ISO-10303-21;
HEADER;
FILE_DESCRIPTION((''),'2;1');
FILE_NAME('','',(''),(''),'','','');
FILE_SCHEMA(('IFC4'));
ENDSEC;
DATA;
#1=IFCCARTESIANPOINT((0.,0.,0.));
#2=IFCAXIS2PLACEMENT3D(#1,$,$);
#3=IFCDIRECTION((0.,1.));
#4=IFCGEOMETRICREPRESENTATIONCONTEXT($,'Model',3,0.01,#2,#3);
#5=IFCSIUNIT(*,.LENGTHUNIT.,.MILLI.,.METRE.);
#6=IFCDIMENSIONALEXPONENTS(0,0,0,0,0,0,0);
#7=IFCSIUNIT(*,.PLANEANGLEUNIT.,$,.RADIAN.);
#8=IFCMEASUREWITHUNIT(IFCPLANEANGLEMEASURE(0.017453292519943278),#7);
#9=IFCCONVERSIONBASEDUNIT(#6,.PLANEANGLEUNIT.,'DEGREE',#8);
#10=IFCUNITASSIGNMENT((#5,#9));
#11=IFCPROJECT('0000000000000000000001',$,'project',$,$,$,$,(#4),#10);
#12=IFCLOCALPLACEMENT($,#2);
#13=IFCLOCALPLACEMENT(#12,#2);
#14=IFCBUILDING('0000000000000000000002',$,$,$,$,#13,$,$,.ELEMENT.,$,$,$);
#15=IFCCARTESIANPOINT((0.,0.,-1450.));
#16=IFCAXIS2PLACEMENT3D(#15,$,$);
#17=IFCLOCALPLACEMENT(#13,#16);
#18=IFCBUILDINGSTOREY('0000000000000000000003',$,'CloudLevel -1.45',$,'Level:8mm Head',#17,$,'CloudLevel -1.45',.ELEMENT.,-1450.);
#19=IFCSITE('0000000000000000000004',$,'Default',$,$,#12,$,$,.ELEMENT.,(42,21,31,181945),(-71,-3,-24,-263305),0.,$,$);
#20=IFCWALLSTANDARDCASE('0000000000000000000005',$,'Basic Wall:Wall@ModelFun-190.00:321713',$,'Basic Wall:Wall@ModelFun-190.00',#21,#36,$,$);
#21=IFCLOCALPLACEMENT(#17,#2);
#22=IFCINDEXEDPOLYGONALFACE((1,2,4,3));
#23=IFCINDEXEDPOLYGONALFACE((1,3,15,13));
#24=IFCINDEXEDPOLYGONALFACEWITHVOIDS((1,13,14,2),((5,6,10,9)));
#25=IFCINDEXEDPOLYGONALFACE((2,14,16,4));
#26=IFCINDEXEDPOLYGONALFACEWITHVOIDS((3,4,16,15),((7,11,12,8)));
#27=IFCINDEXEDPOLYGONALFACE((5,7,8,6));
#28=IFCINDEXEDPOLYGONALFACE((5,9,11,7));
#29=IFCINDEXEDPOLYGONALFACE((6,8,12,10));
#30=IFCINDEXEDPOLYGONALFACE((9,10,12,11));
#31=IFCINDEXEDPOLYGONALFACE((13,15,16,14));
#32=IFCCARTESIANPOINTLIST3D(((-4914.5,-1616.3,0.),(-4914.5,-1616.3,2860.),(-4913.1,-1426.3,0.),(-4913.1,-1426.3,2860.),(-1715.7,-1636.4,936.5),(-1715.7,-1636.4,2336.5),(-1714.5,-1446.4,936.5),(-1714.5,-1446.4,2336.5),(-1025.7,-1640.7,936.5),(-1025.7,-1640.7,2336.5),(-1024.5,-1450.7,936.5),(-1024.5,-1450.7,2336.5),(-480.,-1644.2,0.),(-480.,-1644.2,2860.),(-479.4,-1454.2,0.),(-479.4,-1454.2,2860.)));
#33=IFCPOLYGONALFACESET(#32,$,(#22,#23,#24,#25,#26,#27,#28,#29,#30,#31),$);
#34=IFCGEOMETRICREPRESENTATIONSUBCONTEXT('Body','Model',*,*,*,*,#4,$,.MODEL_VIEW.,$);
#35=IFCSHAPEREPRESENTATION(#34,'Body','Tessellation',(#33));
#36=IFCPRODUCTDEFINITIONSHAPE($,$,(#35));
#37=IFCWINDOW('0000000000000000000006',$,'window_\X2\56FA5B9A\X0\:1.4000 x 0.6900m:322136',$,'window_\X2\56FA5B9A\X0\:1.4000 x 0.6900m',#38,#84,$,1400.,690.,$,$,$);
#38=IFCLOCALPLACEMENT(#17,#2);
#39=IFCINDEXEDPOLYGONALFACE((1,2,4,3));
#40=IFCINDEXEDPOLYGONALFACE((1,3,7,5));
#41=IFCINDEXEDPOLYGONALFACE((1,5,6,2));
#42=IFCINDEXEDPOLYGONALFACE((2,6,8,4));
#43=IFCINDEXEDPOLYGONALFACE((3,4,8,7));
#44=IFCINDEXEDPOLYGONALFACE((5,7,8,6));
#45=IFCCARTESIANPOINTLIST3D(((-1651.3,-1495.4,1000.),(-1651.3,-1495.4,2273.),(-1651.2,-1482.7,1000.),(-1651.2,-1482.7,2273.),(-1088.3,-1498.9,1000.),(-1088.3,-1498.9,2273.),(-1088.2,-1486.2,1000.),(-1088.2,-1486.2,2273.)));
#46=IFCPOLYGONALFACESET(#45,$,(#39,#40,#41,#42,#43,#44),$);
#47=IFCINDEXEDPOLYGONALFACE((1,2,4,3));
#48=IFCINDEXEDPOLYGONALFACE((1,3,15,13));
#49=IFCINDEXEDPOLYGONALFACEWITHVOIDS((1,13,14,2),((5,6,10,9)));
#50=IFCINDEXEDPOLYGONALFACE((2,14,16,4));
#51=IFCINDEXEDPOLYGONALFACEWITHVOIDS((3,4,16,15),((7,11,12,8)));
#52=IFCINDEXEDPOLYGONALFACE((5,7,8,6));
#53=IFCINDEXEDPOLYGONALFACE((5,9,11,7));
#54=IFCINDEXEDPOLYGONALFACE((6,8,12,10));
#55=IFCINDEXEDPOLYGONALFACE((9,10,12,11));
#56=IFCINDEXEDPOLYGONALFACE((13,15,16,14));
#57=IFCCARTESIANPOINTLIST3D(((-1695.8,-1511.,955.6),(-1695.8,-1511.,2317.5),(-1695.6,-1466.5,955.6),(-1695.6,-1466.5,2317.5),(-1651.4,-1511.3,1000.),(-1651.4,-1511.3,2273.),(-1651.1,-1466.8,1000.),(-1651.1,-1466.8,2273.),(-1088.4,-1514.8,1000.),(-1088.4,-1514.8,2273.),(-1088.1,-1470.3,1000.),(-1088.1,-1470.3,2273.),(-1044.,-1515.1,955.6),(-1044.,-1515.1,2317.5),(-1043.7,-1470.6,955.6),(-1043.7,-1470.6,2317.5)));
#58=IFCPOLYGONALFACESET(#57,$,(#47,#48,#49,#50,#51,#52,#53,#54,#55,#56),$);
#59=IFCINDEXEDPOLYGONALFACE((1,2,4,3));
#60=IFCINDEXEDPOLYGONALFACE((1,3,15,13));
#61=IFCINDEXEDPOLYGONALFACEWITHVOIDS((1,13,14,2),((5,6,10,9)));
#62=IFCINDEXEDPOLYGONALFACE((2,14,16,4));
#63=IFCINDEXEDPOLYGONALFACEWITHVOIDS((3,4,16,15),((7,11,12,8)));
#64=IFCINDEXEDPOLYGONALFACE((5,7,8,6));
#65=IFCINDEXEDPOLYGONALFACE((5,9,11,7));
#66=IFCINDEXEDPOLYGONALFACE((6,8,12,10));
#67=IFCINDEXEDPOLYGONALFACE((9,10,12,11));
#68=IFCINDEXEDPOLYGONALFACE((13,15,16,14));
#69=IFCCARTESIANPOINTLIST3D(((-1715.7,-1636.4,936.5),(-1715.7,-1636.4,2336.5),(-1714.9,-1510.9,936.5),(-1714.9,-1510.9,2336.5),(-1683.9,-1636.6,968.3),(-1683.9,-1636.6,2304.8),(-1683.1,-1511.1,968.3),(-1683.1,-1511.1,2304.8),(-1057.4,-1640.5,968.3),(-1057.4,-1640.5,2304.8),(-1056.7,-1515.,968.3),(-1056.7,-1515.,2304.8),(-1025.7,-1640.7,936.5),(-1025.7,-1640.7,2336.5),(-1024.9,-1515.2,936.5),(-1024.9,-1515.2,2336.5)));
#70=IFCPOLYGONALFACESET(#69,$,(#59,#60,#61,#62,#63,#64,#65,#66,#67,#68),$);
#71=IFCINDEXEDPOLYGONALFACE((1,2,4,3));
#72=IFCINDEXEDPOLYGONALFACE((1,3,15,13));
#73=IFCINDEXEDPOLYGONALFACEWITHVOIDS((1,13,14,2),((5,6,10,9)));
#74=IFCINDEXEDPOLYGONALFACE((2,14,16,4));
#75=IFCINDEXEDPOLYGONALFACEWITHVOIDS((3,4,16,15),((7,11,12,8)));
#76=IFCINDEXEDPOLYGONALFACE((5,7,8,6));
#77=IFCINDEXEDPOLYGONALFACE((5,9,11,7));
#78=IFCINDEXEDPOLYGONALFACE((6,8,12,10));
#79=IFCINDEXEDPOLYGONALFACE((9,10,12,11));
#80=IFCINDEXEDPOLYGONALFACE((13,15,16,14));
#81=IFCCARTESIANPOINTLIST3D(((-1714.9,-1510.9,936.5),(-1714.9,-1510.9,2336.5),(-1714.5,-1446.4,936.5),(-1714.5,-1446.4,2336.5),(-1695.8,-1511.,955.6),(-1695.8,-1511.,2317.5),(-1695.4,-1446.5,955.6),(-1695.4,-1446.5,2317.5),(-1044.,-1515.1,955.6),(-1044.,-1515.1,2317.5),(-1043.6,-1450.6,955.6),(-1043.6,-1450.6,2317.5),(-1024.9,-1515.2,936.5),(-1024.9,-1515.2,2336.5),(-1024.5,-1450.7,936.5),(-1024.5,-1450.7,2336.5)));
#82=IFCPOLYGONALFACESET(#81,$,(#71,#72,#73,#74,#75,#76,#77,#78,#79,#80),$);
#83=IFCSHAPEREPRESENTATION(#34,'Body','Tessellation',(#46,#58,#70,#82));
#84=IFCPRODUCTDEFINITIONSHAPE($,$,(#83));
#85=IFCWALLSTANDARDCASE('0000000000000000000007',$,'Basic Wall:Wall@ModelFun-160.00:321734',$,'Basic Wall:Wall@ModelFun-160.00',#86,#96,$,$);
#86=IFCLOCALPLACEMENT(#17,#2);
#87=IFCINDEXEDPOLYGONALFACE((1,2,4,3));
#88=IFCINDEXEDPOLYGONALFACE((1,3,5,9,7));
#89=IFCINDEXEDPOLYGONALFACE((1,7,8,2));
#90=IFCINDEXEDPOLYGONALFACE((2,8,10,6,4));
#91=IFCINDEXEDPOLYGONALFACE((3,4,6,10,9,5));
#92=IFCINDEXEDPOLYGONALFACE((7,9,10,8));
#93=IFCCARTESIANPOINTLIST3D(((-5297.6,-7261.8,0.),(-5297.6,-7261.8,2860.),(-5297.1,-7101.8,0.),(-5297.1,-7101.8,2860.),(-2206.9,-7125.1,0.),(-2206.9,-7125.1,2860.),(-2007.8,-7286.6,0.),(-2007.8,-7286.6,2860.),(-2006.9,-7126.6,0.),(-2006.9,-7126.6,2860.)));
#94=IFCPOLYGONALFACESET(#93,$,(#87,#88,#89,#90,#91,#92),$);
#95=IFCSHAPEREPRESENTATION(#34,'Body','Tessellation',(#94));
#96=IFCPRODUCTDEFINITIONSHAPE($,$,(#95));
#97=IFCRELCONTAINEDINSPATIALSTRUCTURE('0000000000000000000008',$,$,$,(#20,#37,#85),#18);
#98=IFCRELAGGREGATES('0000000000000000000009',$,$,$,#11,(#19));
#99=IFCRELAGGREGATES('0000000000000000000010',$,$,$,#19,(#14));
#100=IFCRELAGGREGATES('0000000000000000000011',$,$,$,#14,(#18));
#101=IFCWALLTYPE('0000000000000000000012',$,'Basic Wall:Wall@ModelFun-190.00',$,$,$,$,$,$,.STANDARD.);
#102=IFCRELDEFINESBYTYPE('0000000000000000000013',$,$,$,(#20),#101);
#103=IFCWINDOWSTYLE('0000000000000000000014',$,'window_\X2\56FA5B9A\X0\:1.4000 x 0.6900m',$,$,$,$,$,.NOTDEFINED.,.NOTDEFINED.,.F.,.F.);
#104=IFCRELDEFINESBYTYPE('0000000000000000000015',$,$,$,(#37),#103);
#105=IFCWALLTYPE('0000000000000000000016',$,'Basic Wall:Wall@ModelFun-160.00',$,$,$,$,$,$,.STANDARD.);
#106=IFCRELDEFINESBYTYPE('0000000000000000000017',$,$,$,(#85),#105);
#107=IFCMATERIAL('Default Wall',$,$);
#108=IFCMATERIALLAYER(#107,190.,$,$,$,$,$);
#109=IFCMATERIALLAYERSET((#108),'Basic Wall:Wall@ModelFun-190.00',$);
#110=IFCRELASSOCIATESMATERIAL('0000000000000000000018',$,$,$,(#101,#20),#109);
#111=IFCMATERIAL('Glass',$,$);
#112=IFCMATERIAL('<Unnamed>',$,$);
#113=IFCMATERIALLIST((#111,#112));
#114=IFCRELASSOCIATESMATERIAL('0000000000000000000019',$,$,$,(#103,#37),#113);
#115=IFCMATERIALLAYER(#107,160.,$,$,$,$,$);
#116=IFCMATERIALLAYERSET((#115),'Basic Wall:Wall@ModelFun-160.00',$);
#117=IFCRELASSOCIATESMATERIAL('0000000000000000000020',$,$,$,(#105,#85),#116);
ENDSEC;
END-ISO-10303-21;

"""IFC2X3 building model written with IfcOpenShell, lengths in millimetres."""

from ifc_helpers import new_model, entity, si_unit, converted_unit, direction, frame, frame_2d, origin, place, context, subcontext, project, spatial, polyline, rectangle, outline, extrude, source, transform, mapped, material, material_list, layer, layer_set, layer_usage, type_object, type_shapes, element, fill, save


model = new_model("IFC2X3")

# Units and contexts
model_context = context("Model", 3, precision=0.01, world=origin(), true_north=direction((0.0, 1.0)))
body_context = subcontext(model_context, "Body", "Model", "MODEL_VIEW")
ifc_project = project(units=[si_unit("LENGTHUNIT", "METRE", prefix="MILLI"), converted_unit("PLANEANGLEUNIT", "DEGREE", entity("IfcPlaneAngleMeasure", 0.017453292519943278), si_unit("PLANEANGLEUNIT", "RADIAN"), dimensions=[0, 0, 0, 0, 0, 0, 0])], contexts=[model_context])

# Site, building, storey
site_placement = place(None, origin())
site = spatial("IfcSite", under=ifc_project, at=site_placement, Name="Default", CompositionType="ELEMENT", RefLatitude=(42, 21, 31, 181945), RefLongitude=(-71, -3, -24, -263305), RefElevation=0.0)
building_placement = place(site_placement, origin())
building = spatial("IfcBuilding", under=site, at=building_placement, CompositionType="ELEMENT")
storey_placement = place(building_placement, frame((0.0, 0.0, -1450.0)))
storey = spatial("IfcBuildingStorey", under=building, at=storey_placement, Name="CloudLevel -1.45", ObjectType="Level:8mm Head", LongName="CloudLevel -1.45", CompositionType="ELEMENT", Elevation=-1450.0)

# Shared definitions
ifc_material_1 = material(Name="Default Wall")
ifc_material_2 = material(Name="Glass")
ifc_material_3 = material(Name="<Unnamed>")
ifc_material_list = material_list([ifc_material_2, ifc_material_3])

# Wall, opening, window
ifc_layer_1 = layer(ifc_material_1, 190.0)
ifc_layer_set_1 = layer_set([ifc_layer_1], Name="Basic Wall:Wall@ModelFun-190.00")
ifc_layer_usage_1 = layer_usage(ifc_layer_set_1, "AXIS2", "NEGATIVE", 95.0)
wall_type_1 = type_object("IfcWallType", Name="Basic Wall:Wall@ModelFun-190.00", PredefinedType="STANDARD", material=ifc_layer_set_1)
wall_1_placement = place(storey_placement, frame((-479.4, -1549.2, 0.0), z_axis=(0.0, 0.0, 1.0), x_axis=(-0.99998, 0.006278, 0.0)))
wall_1 = element("IfcWallStandardCase", 1, at=wall_1_placement, inside=storey, type_object=wall_type_1, material=ifc_layer_usage_1, Name="Basic Wall:Wall@ModelFun-190.00:321713", ObjectType="Basic Wall:Wall@ModelFun-190.00", context=body_context, shape_type="SweptSolid", body=[
    extrude(outline(polyline([(4434.4, -95.0), (4434.6, 95.0), (4194.6, 95.0), (1694.8, 95.0), (1494.8, 95.0), (0.0, 95.0), (0.6, -95.0), (142.8, -95.0), (342.8, -95.0), (1346.6, -95.0), (1586.6, -95.0), (4434.4, -95.0)])), origin(), (0.0, 0.0, 1.0), 2860.0),
])
opening_1_placement = place(wall_1_placement, frame((1235.7, 95.0, 936.5)))
opening_1 = element("IfcOpeningElement", 2, at=opening_1_placement, cuts=wall_1, ObjectType="Opening", context=body_context, shape_type="SweptSolid", body=[
    extrude(rectangle(XDim=1400.0, YDim=690.0, at=frame_2d((700.0, 345.0), x_axis=(-1.0, 0.0))), frame((0.0, 0.0, 0.0), z_axis=(0.0, -1.0, 0.0), x_axis=(0.0, 0.0, 1.0)), (0.0, 0.0, 1.0), 190.0),
])
window_style_1 = type_object("IfcWindowStyle", Name="window_固定:1.4000 x 0.6900m", ConstructionType="NOTDEFINED", OperationType="NOTDEFINED", ParameterTakesPrecedence=False, Sizeable=False, material=ifc_material_list)
shared_shape_1 = source(origin(), body_context, "Body", "SweptSolid", [
    extrude(rectangle(XDim=563.0, YDim=12.7, at=frame_2d((0.0, 0.0), x_axis=(1.0, 0.0))), frame((421.2, 147.8, 63.5)), (0.0, 0.0, 1.0), 1273.0),
    extrude(outline(polyline([(-325.9, -680.9), (325.9, -680.9), (325.9, 680.9), (-325.9, 680.9), (-325.9, -680.9)]), holes=[polyline([(-281.5, -636.5), (-281.5, 636.5), (281.5, 636.5), (281.5, -636.5), (-281.5, -636.5)])]), frame((421.2, 170.0, 700.0), z_axis=(0.0, -1.0, 0.0), x_axis=(-1.0, 0.0, 0.0)), (0.0, 0.0, 1.0), 44.4),
    extrude(outline(polyline([(-345.0, -700.0), (345.0, -700.0), (345.0, 700.0), (-345.0, 700.0), (-345.0, -700.0)]), holes=[polyline([(-313.2, -668.2), (-313.2, 668.2), (313.2, 668.2), (313.2, -668.2), (-313.2, -668.2)])]), frame((421.2, 125.5, 700.0), z_axis=(0.0, -1.0, 0.0), x_axis=(-1.0, 0.0, 0.0)), (0.0, 0.0, 1.0), 125.5),
    extrude(outline(polyline([(-700.0, -345.0), (700.0, -345.0), (700.0, 345.0), (-700.0, 345.0), (-700.0, -345.0)]), holes=[polyline([(-680.9, -325.9), (-680.9, 325.9), (680.9, 325.9), (680.9, -325.9), (-680.9, -325.9)])]), frame((421.2, 190.0, 700.0), z_axis=(0.0, -1.0, 0.0), x_axis=(0.0, 0.0, -1.0)), (0.0, 0.0, 1.0), 64.4),
])
type_shapes(window_style_1, [shared_shape_1])
window_1_placement = place(opening_1_placement, frame((76.2, 0.0, 0.0), z_axis=(0.0, 0.0, 1.0), x_axis=(-1.0, 0.0, 0.0)))
window_1 = element("IfcWindow", 3, at=window_1_placement, inside=storey, type_object=window_style_1, material=ifc_material_list, Name="window_固定:1.4000 x 0.6900m:322136", ObjectType="window_固定:1.4000 x 0.6900m", OverallHeight=1400.0, OverallWidth=690.0, context=body_context, shape_type="MappedRepresentation", body=[
    mapped(shared_shape_1, transform((0.0, 0.0, 0.0), scale=1.0)),
])
fill(opening_1, window_1)

# Wall
ifc_layer_2 = layer(ifc_material_1, 160.0)
ifc_layer_set_2 = layer_set([ifc_layer_2], Name="Basic Wall:Wall@ModelFun-160.00")
ifc_layer_usage_2 = layer_usage(ifc_layer_set_2, "AXIS2", "NEGATIVE", 80.0)
wall_type_2 = type_object("IfcWallType", Name="Basic Wall:Wall@ModelFun-160.00", PredefinedType="STANDARD", material=ifc_layer_set_2)
wall_2_placement = place(storey_placement, frame((-2007.2, -7206.6, 0.0), z_axis=(0.0, 0.0, 1.0), x_axis=(-0.999972, 0.007535, 0.0)))
element("IfcWallStandardCase", 4, at=wall_2_placement, inside=storey, type_object=wall_type_2, material=ifc_layer_usage_2, Name="Basic Wall:Wall@ModelFun-160.00:321734", ObjectType="Basic Wall:Wall@ModelFun-160.00", context=body_context, shape_type="SweptSolid", body=[
    extrude(outline(polyline([(3290.7, -80.0), (3289.9, 80.0), (0.0, 80.0), (0.3, -80.0), (200.3, -80.0), (3290.7, -80.0)])), origin(), (0.0, 0.0, 1.0), 2860.0),
])

save(model, "model.ifc")
